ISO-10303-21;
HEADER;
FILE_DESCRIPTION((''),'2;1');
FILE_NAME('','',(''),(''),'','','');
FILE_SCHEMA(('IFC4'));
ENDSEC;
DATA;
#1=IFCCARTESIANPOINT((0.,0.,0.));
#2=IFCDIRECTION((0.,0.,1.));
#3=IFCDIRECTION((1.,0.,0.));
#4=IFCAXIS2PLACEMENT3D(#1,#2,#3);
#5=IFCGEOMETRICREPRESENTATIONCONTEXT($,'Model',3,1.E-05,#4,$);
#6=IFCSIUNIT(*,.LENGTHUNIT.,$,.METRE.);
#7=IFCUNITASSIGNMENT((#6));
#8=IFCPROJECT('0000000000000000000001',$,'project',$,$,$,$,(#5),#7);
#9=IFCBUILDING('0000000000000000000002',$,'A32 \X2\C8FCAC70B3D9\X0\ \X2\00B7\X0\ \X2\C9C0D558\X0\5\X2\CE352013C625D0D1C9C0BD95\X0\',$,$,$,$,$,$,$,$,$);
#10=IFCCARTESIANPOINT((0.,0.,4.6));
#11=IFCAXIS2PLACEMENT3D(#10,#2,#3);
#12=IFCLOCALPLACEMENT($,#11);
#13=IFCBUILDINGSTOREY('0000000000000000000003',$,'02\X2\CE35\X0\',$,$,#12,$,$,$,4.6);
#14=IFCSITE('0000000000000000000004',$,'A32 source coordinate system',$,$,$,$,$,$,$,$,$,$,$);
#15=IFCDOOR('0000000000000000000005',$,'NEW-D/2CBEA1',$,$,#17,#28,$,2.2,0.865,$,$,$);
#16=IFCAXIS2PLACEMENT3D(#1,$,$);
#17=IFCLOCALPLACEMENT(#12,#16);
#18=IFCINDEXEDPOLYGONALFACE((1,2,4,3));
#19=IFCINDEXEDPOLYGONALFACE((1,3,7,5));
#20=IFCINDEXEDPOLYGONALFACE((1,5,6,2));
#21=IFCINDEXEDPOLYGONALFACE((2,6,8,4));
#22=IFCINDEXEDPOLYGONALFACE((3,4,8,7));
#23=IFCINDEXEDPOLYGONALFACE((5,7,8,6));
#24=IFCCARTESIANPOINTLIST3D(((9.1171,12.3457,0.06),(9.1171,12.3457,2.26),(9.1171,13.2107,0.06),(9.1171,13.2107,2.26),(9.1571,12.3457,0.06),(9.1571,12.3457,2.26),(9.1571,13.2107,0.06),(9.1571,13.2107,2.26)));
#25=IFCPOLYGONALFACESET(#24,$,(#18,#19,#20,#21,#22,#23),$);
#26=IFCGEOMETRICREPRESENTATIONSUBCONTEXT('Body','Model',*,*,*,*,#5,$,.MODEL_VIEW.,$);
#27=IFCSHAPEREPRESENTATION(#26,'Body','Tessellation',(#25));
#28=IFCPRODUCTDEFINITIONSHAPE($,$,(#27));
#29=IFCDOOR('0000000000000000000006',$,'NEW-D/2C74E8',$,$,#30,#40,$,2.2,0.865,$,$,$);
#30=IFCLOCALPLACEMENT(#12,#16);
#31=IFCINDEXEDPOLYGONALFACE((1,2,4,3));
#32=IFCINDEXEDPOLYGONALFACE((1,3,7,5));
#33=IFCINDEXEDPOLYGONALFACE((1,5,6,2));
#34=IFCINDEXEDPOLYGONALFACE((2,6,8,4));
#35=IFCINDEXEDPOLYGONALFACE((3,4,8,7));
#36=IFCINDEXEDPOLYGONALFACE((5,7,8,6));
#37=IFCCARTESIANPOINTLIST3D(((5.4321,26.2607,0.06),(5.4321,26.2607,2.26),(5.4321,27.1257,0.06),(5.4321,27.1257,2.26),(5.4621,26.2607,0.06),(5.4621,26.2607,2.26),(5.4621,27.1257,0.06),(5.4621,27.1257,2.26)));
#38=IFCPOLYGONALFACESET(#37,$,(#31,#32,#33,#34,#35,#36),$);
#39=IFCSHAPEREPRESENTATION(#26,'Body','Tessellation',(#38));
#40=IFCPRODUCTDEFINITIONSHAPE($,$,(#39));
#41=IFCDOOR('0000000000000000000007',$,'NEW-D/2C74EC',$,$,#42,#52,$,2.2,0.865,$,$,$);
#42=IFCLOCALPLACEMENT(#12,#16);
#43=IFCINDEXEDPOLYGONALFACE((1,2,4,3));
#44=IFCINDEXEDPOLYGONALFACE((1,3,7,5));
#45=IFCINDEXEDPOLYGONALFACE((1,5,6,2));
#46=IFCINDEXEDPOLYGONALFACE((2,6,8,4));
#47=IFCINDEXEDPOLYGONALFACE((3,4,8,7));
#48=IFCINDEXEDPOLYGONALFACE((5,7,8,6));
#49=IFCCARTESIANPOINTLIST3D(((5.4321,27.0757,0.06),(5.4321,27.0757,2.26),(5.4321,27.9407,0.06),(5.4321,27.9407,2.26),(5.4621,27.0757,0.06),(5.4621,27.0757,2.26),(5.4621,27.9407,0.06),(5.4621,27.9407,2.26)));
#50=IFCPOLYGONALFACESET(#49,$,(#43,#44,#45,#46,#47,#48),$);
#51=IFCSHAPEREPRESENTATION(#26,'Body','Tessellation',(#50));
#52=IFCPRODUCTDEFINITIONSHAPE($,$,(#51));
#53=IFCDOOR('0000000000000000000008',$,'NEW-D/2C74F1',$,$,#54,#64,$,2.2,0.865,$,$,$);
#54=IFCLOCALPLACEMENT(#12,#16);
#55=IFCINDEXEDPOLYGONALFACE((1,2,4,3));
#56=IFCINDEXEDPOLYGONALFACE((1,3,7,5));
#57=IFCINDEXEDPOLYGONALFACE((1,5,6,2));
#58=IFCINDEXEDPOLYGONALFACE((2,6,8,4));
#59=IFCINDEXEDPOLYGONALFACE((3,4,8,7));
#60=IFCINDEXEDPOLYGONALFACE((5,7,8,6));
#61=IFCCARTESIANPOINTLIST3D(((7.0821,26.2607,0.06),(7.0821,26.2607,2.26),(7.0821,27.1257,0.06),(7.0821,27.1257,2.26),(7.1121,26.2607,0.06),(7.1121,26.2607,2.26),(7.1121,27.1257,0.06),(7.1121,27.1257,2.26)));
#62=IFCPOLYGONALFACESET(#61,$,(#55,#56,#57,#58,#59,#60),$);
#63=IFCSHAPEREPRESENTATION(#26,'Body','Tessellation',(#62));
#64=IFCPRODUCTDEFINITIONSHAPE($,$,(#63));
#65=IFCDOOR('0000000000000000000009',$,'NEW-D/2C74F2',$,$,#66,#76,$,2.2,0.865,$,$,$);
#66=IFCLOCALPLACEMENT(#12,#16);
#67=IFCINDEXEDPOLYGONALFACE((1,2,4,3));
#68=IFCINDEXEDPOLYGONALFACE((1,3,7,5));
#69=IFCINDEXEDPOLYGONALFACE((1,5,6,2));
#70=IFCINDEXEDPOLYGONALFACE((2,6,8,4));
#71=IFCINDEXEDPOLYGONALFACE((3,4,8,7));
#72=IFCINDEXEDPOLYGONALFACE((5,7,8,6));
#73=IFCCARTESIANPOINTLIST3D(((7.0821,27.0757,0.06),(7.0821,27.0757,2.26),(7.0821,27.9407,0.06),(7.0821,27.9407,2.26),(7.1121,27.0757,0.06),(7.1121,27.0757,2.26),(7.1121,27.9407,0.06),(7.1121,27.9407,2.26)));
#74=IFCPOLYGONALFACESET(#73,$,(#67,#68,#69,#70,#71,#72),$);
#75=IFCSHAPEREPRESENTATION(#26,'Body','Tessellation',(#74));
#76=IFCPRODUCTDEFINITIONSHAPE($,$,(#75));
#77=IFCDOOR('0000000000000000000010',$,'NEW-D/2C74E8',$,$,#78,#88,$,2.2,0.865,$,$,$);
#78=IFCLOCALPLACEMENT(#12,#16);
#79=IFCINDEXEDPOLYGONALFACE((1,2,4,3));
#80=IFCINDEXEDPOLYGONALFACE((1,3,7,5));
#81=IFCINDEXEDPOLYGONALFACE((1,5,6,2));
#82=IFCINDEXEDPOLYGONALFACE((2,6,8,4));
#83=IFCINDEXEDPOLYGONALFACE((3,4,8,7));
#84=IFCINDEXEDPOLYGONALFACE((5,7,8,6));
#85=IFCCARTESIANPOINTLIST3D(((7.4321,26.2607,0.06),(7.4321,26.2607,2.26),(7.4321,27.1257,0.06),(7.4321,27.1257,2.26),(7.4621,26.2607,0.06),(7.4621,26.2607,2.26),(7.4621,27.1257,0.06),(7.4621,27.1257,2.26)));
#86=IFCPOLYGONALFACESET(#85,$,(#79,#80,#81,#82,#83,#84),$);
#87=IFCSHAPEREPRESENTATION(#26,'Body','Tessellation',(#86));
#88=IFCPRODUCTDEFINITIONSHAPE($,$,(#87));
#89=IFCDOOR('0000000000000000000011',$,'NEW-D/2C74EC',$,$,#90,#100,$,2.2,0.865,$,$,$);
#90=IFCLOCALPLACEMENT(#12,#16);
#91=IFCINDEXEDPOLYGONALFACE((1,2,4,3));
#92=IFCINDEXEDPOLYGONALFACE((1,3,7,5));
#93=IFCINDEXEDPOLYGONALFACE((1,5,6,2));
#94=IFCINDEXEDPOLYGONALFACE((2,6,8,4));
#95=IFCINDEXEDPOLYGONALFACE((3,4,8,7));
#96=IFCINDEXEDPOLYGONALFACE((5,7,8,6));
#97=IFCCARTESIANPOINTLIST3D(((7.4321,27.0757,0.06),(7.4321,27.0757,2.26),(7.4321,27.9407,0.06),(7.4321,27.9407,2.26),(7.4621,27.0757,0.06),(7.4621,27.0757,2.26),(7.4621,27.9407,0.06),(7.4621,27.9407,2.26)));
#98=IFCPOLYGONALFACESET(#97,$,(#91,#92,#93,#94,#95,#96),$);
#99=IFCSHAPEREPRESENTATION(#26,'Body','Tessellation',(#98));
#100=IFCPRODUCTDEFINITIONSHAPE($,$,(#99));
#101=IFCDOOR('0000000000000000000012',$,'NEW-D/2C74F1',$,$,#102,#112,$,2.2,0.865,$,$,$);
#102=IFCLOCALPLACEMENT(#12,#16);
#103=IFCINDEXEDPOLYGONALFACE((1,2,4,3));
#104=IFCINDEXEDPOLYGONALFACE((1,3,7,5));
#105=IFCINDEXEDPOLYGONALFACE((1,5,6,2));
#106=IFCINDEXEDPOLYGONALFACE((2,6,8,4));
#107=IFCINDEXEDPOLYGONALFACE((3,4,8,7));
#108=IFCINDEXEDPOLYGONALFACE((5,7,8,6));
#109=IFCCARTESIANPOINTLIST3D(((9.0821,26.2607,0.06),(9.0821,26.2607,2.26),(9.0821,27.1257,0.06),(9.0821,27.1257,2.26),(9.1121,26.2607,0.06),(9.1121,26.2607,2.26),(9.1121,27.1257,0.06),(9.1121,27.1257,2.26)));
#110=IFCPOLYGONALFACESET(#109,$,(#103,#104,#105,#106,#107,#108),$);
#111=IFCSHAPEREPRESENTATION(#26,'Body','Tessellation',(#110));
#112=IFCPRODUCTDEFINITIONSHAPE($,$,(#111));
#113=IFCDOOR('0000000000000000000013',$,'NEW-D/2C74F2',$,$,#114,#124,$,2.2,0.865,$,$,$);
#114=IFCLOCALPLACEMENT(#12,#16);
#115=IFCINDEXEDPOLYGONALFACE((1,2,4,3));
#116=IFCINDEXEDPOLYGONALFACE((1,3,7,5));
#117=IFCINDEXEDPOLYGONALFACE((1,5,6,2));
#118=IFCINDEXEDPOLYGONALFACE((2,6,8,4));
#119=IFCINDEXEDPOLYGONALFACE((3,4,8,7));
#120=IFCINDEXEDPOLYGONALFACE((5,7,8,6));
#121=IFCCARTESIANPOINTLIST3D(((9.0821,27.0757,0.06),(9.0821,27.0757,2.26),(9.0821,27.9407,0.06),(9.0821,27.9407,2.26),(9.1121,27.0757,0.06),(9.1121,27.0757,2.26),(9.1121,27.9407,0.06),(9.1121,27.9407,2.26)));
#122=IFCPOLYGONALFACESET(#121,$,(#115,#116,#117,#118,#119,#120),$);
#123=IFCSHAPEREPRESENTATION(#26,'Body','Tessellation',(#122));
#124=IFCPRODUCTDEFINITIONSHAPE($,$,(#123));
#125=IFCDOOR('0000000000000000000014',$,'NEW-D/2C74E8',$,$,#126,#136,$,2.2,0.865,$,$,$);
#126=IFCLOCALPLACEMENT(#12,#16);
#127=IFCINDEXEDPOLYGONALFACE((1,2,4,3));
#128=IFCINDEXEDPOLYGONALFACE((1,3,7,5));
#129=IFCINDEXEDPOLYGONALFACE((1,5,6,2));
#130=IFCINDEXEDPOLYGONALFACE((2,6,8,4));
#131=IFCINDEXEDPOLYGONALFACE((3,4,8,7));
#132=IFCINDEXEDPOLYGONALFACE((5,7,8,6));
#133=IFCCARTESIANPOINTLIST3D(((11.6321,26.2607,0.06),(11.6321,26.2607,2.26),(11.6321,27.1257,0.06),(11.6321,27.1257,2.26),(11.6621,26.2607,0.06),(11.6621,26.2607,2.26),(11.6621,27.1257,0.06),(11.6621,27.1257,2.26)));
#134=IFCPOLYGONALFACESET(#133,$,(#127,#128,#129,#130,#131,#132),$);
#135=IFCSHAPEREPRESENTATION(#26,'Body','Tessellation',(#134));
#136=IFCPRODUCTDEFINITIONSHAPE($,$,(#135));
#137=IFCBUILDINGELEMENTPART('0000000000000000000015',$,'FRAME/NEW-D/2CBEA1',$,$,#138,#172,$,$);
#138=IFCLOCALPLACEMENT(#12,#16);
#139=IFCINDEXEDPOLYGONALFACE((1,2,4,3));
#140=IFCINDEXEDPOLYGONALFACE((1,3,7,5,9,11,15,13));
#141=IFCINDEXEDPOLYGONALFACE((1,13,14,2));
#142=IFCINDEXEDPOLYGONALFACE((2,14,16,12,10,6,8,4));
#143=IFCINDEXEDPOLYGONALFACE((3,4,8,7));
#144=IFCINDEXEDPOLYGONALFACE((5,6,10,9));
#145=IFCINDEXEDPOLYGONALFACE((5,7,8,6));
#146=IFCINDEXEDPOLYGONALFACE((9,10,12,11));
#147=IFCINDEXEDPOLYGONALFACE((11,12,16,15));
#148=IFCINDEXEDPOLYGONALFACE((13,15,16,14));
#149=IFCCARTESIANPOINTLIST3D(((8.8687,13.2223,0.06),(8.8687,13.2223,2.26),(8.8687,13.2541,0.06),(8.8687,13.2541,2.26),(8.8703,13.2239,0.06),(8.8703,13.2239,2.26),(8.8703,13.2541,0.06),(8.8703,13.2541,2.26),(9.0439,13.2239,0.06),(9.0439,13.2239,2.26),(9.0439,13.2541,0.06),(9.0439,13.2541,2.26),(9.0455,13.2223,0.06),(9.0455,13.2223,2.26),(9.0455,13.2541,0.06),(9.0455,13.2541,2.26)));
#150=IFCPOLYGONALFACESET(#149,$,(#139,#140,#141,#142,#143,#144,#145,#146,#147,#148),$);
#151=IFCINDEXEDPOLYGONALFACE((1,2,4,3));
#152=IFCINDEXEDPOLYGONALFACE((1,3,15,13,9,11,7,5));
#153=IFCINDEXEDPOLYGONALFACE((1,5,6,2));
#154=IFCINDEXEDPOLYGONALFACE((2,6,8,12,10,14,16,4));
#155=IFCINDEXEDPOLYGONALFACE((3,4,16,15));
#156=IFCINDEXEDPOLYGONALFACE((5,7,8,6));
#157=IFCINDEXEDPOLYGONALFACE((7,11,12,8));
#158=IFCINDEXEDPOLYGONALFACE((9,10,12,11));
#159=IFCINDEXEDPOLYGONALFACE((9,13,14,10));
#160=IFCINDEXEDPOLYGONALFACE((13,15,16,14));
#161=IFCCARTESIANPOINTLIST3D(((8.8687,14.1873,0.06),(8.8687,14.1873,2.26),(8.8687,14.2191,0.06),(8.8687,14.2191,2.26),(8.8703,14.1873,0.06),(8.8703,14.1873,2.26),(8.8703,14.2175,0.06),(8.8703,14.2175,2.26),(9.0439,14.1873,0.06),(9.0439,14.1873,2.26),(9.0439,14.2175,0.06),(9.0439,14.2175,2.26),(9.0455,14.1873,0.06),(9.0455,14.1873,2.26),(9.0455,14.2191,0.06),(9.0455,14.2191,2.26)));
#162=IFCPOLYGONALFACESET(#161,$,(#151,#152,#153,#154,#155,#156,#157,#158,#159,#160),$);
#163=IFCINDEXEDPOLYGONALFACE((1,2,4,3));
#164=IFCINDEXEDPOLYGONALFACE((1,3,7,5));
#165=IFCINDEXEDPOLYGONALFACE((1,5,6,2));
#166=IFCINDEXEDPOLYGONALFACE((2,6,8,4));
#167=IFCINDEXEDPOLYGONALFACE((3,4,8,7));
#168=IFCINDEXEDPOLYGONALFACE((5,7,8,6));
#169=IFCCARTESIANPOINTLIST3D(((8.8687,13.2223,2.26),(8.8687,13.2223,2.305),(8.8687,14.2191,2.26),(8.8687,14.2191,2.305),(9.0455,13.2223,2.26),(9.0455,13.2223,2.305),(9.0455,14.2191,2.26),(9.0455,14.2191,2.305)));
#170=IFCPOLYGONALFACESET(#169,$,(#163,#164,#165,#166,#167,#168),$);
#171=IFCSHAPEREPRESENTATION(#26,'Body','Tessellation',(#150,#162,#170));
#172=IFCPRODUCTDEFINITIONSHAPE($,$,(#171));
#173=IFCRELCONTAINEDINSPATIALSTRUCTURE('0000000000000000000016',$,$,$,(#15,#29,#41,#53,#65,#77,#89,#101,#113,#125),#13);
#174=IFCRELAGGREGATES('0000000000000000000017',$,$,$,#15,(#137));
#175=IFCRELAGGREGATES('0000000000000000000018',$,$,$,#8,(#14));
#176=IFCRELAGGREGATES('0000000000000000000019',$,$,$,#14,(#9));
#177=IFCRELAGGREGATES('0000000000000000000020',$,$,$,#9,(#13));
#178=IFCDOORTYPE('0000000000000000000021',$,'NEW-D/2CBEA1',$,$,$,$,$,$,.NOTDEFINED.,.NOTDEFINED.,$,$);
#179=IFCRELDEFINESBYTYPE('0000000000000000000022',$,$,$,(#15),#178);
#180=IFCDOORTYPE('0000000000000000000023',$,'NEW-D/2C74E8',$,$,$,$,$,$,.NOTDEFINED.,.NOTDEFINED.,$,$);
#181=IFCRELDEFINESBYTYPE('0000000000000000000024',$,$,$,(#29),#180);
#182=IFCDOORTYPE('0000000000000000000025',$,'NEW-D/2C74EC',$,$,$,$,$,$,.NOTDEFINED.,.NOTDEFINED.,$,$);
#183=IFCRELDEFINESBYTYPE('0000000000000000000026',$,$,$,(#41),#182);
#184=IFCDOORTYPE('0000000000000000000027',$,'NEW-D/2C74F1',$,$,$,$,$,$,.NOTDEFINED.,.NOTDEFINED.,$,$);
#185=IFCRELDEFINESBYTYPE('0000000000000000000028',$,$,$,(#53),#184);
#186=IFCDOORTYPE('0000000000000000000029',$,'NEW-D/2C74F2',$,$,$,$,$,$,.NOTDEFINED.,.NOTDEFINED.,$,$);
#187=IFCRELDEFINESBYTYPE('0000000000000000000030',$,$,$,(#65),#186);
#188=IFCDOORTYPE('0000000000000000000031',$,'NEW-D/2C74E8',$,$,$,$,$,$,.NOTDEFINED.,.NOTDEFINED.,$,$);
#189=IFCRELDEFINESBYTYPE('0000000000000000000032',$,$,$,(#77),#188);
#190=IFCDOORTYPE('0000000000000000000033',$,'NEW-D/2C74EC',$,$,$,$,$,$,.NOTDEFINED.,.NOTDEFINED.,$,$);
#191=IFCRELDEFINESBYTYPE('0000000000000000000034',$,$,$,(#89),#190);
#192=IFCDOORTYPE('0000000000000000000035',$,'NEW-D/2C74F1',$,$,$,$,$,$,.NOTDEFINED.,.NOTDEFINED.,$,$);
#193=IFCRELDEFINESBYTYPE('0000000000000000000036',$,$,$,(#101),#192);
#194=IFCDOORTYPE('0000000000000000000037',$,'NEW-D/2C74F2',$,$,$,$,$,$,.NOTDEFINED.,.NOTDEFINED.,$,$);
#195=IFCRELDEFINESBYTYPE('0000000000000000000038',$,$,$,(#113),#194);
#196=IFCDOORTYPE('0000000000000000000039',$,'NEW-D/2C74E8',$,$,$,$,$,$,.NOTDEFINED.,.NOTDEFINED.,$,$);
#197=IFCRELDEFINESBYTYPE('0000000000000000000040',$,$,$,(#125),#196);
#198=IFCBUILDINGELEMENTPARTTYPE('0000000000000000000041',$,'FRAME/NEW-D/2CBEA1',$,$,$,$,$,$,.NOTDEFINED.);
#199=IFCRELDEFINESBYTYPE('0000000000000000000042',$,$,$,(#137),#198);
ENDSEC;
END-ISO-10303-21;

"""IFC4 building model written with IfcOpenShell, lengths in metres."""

from ifc_helpers import new_model, si_unit, frame, origin, origin_with_axes, place, context, subcontext, project, spatial, polyline, outline, extrude, source, transform, mapped, type_object, type_shapes, element, aggregate, save


model = new_model("IFC4")

# Units and contexts
model_context = context("Model", 3, precision=1e-05, world=origin_with_axes())
body_context = subcontext(model_context, "Body", "Model", "MODEL_VIEW")
ifc_project = project(units=[si_unit("LENGTHUNIT", "METRE")], contexts=[model_context])

# Site, building, storey
site = spatial("IfcSite", under=ifc_project, Name="A32 source coordinate system")
building = spatial("IfcBuilding", under=site, Name="A32 주거동 · 지하5층–옥탑지붕")
storey_placement = place(None, frame((0.0, 0.0, 4.6), z_axis=(0.0, 0.0, 1.0), x_axis=(1.0, 0.0, 0.0)))
storey = spatial("IfcBuildingStorey", under=building, at=storey_placement, Name="02층", Elevation=4.6)

# Door
door_type_1 = type_object("IfcDoorType", Name="NEW-D/2CBEA1", OperationType="NOTDEFINED", PredefinedType="NOTDEFINED")
shared_shape_1 = source(origin(), body_context, "Body", "SweptSolid", [
    extrude(outline(polyline([(9.1571, 12.3457), (9.1171, 12.3457), (9.1171, 13.2107), (9.1571, 13.2107), (9.1571, 12.3457)])), frame((0.0, 0.0, 0.06)), (0.0, 0.0, 1.0), 2.2),
])
type_shapes(door_type_1, [shared_shape_1])
door_1_placement = place(storey_placement, origin_with_axes())
door_1 = element("IfcDoor", 1, at=door_1_placement, inside=storey, type_object=door_type_1, Name="NEW-D/2CBEA1", OverallHeight=2.2, OverallWidth=0.865, context=body_context, shape_type="MappedRepresentation", body=[
    mapped(shared_shape_1, transform((0.0, 0.0, 0.0), scale=1.0)),
])

# Doors
door_type_2 = type_object("IfcDoorType", Name="NEW-D/2C74E8", OperationType="NOTDEFINED", PredefinedType="NOTDEFINED")
shared_shape_2 = source(origin(), body_context, "Body", "SweptSolid", [
    extrude(outline(polyline([(5.4621, 27.1257), (5.4621, 26.2607), (5.4321, 26.2607), (5.4321, 27.1257), (5.4621, 27.1257)])), frame((0.0, 0.0, 0.06)), (0.0, 0.0, 1.0), 2.2),
])
type_shapes(door_type_2, [shared_shape_2])
door_2_placement = place(storey_placement, origin_with_axes())
element("IfcDoor", 2, at=door_2_placement, inside=storey, type_object=door_type_2, Name="NEW-D/2C74E8", OverallHeight=2.2, OverallWidth=0.865, context=body_context, shape_type="MappedRepresentation", body=[
    mapped(shared_shape_2, transform((0.0, 0.0, 0.0), scale=1.0)),
])
door_type_3 = type_object("IfcDoorType", Name="NEW-D/2C74EC", OperationType="NOTDEFINED", PredefinedType="NOTDEFINED")
shared_shape_3 = source(origin(), body_context, "Body", "SweptSolid", [
    extrude(outline(polyline([(5.4321, 27.9407), (5.4621, 27.9407), (5.4621, 27.0757), (5.4321, 27.0757), (5.4321, 27.9407)])), frame((0.0, 0.0, 0.06)), (0.0, 0.0, 1.0), 2.2),
])
type_shapes(door_type_3, [shared_shape_3])
door_3_placement = place(storey_placement, origin_with_axes())
element("IfcDoor", 3, at=door_3_placement, inside=storey, type_object=door_type_3, Name="NEW-D/2C74EC", OverallHeight=2.2, OverallWidth=0.865, context=body_context, shape_type="MappedRepresentation", body=[
    mapped(shared_shape_3, transform((0.0, 0.0, 0.0), scale=1.0)),
])
door_type_4 = type_object("IfcDoorType", Name="NEW-D/2C74F1", OperationType="NOTDEFINED", PredefinedType="NOTDEFINED")
shared_shape_4 = source(origin(), body_context, "Body", "SweptSolid", [
    extrude(outline(polyline([(7.1121, 26.2607), (7.0821, 26.2607), (7.0821, 27.1257), (7.1121, 27.1257), (7.1121, 26.2607)])), frame((0.0, 0.0, 0.06)), (0.0, 0.0, 1.0), 2.2),
])
type_shapes(door_type_4, [shared_shape_4])
door_4_placement = place(storey_placement, origin_with_axes())
element("IfcDoor", 4, at=door_4_placement, inside=storey, type_object=door_type_4, Name="NEW-D/2C74F1", OverallHeight=2.2, OverallWidth=0.865, context=body_context, shape_type="MappedRepresentation", body=[
    mapped(shared_shape_4, transform((0.0, 0.0, 0.0), scale=1.0)),
])
door_type_5 = type_object("IfcDoorType", Name="NEW-D/2C74F2", OperationType="NOTDEFINED", PredefinedType="NOTDEFINED")
shared_shape_5 = source(origin(), body_context, "Body", "SweptSolid", [
    extrude(outline(polyline([(7.0821, 27.0757), (7.0821, 27.9407), (7.1121, 27.9407), (7.1121, 27.0757), (7.0821, 27.0757)])), frame((0.0, 0.0, 0.06)), (0.0, 0.0, 1.0), 2.2),
])
type_shapes(door_type_5, [shared_shape_5])
door_5_placement = place(storey_placement, origin_with_axes())
element("IfcDoor", 5, at=door_5_placement, inside=storey, type_object=door_type_5, Name="NEW-D/2C74F2", OverallHeight=2.2, OverallWidth=0.865, context=body_context, shape_type="MappedRepresentation", body=[
    mapped(shared_shape_5, transform((0.0, 0.0, 0.0), scale=1.0)),
])
door_type_6 = type_object("IfcDoorType", Name="NEW-D/2C74E8", OperationType="NOTDEFINED", PredefinedType="NOTDEFINED")
shared_shape_6 = source(origin(), body_context, "Body", "SweptSolid", [
    extrude(outline(polyline([(7.4621, 27.1257), (7.4621, 26.2607), (7.4321, 26.2607), (7.4321, 27.1257), (7.4621, 27.1257)])), frame((0.0, 0.0, 0.06)), (0.0, 0.0, 1.0), 2.2),
])
type_shapes(door_type_6, [shared_shape_6])
door_6_placement = place(storey_placement, origin_with_axes())
element("IfcDoor", 6, at=door_6_placement, inside=storey, type_object=door_type_6, Name="NEW-D/2C74E8", OverallHeight=2.2, OverallWidth=0.865, context=body_context, shape_type="MappedRepresentation", body=[
    mapped(shared_shape_6, transform((0.0, 0.0, 0.0), scale=1.0)),
])
door_type_7 = type_object("IfcDoorType", Name="NEW-D/2C74EC", OperationType="NOTDEFINED", PredefinedType="NOTDEFINED")
shared_shape_7 = source(origin(), body_context, "Body", "SweptSolid", [
    extrude(outline(polyline([(7.4321, 27.9407), (7.4621, 27.9407), (7.4621, 27.0757), (7.4321, 27.0757), (7.4321, 27.9407)])), frame((0.0, 0.0, 0.06)), (0.0, 0.0, 1.0), 2.2),
])
type_shapes(door_type_7, [shared_shape_7])
door_7_placement = place(storey_placement, origin_with_axes())
element("IfcDoor", 7, at=door_7_placement, inside=storey, type_object=door_type_7, Name="NEW-D/2C74EC", OverallHeight=2.2, OverallWidth=0.865, context=body_context, shape_type="MappedRepresentation", body=[
    mapped(shared_shape_7, transform((0.0, 0.0, 0.0), scale=1.0)),
])
door_type_8 = type_object("IfcDoorType", Name="NEW-D/2C74F1", OperationType="NOTDEFINED", PredefinedType="NOTDEFINED")
shared_shape_8 = source(origin(), body_context, "Body", "SweptSolid", [
    extrude(outline(polyline([(9.1121, 26.2607), (9.0821, 26.2607), (9.0821, 27.1257), (9.1121, 27.1257), (9.1121, 26.2607)])), frame((0.0, 0.0, 0.06)), (0.0, 0.0, 1.0), 2.2),
])
type_shapes(door_type_8, [shared_shape_8])
door_8_placement = place(storey_placement, origin_with_axes())
element("IfcDoor", 8, at=door_8_placement, inside=storey, type_object=door_type_8, Name="NEW-D/2C74F1", OverallHeight=2.2, OverallWidth=0.865, context=body_context, shape_type="MappedRepresentation", body=[
    mapped(shared_shape_8, transform((0.0, 0.0, 0.0), scale=1.0)),
])
door_type_9 = type_object("IfcDoorType", Name="NEW-D/2C74F2", OperationType="NOTDEFINED", PredefinedType="NOTDEFINED")
shared_shape_9 = source(origin(), body_context, "Body", "SweptSolid", [
    extrude(outline(polyline([(9.0821, 27.0757), (9.0821, 27.9407), (9.1121, 27.9407), (9.1121, 27.0757), (9.0821, 27.0757)])), frame((0.0, 0.0, 0.06)), (0.0, 0.0, 1.0), 2.2),
])
type_shapes(door_type_9, [shared_shape_9])
door_9_placement = place(storey_placement, origin_with_axes())
element("IfcDoor", 9, at=door_9_placement, inside=storey, type_object=door_type_9, Name="NEW-D/2C74F2", OverallHeight=2.2, OverallWidth=0.865, context=body_context, shape_type="MappedRepresentation", body=[
    mapped(shared_shape_9, transform((0.0, 0.0, 0.0), scale=1.0)),
])
door_type_10 = type_object("IfcDoorType", Name="NEW-D/2C74E8", OperationType="NOTDEFINED", PredefinedType="NOTDEFINED")
shared_shape_10 = source(origin(), body_context, "Body", "SweptSolid", [
    extrude(outline(polyline([(11.6621, 27.1257), (11.6621, 26.2607), (11.6321, 26.2607), (11.6321, 27.1257), (11.6621, 27.1257)])), frame((0.0, 0.0, 0.06)), (0.0, 0.0, 1.0), 2.2),
])
type_shapes(door_type_10, [shared_shape_10])
door_10_placement = place(storey_placement, origin_with_axes())
element("IfcDoor", 10, at=door_10_placement, inside=storey, type_object=door_type_10, Name="NEW-D/2C74E8", OverallHeight=2.2, OverallWidth=0.865, context=body_context, shape_type="MappedRepresentation", body=[
    mapped(shared_shape_10, transform((0.0, 0.0, 0.0), scale=1.0)),
])

# Building element part
building_element_part_type_1 = type_object("IfcBuildingElementPartType", Name="FRAME/NEW-D/2CBEA1", PredefinedType="NOTDEFINED")
shared_shape_11 = source(origin(), body_context, "Body", "SweptSolid", [
    extrude(outline(polyline([(8.8703, 13.2239), (9.0439, 13.2239), (9.0439, 13.2541), (9.0455, 13.2541), (9.0455, 13.2223), (8.8687, 13.2223), (8.8687, 13.2541), (8.8703, 13.2541), (8.8703, 13.2239)])), frame((0.0, 0.0, 0.06)), (0.0, 0.0, 1.0), 2.2),
    extrude(outline(polyline([(9.0455, 14.2191), (9.0455, 14.1873), (9.0439, 14.1873), (9.0439, 14.2175), (8.8703, 14.2175), (8.8703, 14.1873), (8.8687, 14.1873), (8.8687, 14.2191), (9.0455, 14.2191)])), frame((0.0, 0.0, 0.06)), (0.0, 0.0, 1.0), 2.2),
    extrude(outline(polyline([(9.0455, 13.2223), (9.0455, 14.2191), (8.8687, 14.2191), (8.8687, 13.2223), (9.0455, 13.2223)])), frame((0.0, 0.0, 2.26)), (0.0, 0.0, 1.0), 0.045),
])
type_shapes(building_element_part_type_1, [shared_shape_11])
building_element_part_1_placement = place(door_1_placement, origin_with_axes())
building_element_part_1 = element("IfcBuildingElementPart", 11, at=building_element_part_1_placement, type_object=building_element_part_type_1, Name="FRAME/NEW-D/2CBEA1", context=body_context, shape_type="MappedRepresentation", body=[
    mapped(shared_shape_11, transform((0.0, 0.0, 0.0), scale=1.0)),
])
aggregate(door_1, [building_element_part_1])

save(model, "model.ifc")
